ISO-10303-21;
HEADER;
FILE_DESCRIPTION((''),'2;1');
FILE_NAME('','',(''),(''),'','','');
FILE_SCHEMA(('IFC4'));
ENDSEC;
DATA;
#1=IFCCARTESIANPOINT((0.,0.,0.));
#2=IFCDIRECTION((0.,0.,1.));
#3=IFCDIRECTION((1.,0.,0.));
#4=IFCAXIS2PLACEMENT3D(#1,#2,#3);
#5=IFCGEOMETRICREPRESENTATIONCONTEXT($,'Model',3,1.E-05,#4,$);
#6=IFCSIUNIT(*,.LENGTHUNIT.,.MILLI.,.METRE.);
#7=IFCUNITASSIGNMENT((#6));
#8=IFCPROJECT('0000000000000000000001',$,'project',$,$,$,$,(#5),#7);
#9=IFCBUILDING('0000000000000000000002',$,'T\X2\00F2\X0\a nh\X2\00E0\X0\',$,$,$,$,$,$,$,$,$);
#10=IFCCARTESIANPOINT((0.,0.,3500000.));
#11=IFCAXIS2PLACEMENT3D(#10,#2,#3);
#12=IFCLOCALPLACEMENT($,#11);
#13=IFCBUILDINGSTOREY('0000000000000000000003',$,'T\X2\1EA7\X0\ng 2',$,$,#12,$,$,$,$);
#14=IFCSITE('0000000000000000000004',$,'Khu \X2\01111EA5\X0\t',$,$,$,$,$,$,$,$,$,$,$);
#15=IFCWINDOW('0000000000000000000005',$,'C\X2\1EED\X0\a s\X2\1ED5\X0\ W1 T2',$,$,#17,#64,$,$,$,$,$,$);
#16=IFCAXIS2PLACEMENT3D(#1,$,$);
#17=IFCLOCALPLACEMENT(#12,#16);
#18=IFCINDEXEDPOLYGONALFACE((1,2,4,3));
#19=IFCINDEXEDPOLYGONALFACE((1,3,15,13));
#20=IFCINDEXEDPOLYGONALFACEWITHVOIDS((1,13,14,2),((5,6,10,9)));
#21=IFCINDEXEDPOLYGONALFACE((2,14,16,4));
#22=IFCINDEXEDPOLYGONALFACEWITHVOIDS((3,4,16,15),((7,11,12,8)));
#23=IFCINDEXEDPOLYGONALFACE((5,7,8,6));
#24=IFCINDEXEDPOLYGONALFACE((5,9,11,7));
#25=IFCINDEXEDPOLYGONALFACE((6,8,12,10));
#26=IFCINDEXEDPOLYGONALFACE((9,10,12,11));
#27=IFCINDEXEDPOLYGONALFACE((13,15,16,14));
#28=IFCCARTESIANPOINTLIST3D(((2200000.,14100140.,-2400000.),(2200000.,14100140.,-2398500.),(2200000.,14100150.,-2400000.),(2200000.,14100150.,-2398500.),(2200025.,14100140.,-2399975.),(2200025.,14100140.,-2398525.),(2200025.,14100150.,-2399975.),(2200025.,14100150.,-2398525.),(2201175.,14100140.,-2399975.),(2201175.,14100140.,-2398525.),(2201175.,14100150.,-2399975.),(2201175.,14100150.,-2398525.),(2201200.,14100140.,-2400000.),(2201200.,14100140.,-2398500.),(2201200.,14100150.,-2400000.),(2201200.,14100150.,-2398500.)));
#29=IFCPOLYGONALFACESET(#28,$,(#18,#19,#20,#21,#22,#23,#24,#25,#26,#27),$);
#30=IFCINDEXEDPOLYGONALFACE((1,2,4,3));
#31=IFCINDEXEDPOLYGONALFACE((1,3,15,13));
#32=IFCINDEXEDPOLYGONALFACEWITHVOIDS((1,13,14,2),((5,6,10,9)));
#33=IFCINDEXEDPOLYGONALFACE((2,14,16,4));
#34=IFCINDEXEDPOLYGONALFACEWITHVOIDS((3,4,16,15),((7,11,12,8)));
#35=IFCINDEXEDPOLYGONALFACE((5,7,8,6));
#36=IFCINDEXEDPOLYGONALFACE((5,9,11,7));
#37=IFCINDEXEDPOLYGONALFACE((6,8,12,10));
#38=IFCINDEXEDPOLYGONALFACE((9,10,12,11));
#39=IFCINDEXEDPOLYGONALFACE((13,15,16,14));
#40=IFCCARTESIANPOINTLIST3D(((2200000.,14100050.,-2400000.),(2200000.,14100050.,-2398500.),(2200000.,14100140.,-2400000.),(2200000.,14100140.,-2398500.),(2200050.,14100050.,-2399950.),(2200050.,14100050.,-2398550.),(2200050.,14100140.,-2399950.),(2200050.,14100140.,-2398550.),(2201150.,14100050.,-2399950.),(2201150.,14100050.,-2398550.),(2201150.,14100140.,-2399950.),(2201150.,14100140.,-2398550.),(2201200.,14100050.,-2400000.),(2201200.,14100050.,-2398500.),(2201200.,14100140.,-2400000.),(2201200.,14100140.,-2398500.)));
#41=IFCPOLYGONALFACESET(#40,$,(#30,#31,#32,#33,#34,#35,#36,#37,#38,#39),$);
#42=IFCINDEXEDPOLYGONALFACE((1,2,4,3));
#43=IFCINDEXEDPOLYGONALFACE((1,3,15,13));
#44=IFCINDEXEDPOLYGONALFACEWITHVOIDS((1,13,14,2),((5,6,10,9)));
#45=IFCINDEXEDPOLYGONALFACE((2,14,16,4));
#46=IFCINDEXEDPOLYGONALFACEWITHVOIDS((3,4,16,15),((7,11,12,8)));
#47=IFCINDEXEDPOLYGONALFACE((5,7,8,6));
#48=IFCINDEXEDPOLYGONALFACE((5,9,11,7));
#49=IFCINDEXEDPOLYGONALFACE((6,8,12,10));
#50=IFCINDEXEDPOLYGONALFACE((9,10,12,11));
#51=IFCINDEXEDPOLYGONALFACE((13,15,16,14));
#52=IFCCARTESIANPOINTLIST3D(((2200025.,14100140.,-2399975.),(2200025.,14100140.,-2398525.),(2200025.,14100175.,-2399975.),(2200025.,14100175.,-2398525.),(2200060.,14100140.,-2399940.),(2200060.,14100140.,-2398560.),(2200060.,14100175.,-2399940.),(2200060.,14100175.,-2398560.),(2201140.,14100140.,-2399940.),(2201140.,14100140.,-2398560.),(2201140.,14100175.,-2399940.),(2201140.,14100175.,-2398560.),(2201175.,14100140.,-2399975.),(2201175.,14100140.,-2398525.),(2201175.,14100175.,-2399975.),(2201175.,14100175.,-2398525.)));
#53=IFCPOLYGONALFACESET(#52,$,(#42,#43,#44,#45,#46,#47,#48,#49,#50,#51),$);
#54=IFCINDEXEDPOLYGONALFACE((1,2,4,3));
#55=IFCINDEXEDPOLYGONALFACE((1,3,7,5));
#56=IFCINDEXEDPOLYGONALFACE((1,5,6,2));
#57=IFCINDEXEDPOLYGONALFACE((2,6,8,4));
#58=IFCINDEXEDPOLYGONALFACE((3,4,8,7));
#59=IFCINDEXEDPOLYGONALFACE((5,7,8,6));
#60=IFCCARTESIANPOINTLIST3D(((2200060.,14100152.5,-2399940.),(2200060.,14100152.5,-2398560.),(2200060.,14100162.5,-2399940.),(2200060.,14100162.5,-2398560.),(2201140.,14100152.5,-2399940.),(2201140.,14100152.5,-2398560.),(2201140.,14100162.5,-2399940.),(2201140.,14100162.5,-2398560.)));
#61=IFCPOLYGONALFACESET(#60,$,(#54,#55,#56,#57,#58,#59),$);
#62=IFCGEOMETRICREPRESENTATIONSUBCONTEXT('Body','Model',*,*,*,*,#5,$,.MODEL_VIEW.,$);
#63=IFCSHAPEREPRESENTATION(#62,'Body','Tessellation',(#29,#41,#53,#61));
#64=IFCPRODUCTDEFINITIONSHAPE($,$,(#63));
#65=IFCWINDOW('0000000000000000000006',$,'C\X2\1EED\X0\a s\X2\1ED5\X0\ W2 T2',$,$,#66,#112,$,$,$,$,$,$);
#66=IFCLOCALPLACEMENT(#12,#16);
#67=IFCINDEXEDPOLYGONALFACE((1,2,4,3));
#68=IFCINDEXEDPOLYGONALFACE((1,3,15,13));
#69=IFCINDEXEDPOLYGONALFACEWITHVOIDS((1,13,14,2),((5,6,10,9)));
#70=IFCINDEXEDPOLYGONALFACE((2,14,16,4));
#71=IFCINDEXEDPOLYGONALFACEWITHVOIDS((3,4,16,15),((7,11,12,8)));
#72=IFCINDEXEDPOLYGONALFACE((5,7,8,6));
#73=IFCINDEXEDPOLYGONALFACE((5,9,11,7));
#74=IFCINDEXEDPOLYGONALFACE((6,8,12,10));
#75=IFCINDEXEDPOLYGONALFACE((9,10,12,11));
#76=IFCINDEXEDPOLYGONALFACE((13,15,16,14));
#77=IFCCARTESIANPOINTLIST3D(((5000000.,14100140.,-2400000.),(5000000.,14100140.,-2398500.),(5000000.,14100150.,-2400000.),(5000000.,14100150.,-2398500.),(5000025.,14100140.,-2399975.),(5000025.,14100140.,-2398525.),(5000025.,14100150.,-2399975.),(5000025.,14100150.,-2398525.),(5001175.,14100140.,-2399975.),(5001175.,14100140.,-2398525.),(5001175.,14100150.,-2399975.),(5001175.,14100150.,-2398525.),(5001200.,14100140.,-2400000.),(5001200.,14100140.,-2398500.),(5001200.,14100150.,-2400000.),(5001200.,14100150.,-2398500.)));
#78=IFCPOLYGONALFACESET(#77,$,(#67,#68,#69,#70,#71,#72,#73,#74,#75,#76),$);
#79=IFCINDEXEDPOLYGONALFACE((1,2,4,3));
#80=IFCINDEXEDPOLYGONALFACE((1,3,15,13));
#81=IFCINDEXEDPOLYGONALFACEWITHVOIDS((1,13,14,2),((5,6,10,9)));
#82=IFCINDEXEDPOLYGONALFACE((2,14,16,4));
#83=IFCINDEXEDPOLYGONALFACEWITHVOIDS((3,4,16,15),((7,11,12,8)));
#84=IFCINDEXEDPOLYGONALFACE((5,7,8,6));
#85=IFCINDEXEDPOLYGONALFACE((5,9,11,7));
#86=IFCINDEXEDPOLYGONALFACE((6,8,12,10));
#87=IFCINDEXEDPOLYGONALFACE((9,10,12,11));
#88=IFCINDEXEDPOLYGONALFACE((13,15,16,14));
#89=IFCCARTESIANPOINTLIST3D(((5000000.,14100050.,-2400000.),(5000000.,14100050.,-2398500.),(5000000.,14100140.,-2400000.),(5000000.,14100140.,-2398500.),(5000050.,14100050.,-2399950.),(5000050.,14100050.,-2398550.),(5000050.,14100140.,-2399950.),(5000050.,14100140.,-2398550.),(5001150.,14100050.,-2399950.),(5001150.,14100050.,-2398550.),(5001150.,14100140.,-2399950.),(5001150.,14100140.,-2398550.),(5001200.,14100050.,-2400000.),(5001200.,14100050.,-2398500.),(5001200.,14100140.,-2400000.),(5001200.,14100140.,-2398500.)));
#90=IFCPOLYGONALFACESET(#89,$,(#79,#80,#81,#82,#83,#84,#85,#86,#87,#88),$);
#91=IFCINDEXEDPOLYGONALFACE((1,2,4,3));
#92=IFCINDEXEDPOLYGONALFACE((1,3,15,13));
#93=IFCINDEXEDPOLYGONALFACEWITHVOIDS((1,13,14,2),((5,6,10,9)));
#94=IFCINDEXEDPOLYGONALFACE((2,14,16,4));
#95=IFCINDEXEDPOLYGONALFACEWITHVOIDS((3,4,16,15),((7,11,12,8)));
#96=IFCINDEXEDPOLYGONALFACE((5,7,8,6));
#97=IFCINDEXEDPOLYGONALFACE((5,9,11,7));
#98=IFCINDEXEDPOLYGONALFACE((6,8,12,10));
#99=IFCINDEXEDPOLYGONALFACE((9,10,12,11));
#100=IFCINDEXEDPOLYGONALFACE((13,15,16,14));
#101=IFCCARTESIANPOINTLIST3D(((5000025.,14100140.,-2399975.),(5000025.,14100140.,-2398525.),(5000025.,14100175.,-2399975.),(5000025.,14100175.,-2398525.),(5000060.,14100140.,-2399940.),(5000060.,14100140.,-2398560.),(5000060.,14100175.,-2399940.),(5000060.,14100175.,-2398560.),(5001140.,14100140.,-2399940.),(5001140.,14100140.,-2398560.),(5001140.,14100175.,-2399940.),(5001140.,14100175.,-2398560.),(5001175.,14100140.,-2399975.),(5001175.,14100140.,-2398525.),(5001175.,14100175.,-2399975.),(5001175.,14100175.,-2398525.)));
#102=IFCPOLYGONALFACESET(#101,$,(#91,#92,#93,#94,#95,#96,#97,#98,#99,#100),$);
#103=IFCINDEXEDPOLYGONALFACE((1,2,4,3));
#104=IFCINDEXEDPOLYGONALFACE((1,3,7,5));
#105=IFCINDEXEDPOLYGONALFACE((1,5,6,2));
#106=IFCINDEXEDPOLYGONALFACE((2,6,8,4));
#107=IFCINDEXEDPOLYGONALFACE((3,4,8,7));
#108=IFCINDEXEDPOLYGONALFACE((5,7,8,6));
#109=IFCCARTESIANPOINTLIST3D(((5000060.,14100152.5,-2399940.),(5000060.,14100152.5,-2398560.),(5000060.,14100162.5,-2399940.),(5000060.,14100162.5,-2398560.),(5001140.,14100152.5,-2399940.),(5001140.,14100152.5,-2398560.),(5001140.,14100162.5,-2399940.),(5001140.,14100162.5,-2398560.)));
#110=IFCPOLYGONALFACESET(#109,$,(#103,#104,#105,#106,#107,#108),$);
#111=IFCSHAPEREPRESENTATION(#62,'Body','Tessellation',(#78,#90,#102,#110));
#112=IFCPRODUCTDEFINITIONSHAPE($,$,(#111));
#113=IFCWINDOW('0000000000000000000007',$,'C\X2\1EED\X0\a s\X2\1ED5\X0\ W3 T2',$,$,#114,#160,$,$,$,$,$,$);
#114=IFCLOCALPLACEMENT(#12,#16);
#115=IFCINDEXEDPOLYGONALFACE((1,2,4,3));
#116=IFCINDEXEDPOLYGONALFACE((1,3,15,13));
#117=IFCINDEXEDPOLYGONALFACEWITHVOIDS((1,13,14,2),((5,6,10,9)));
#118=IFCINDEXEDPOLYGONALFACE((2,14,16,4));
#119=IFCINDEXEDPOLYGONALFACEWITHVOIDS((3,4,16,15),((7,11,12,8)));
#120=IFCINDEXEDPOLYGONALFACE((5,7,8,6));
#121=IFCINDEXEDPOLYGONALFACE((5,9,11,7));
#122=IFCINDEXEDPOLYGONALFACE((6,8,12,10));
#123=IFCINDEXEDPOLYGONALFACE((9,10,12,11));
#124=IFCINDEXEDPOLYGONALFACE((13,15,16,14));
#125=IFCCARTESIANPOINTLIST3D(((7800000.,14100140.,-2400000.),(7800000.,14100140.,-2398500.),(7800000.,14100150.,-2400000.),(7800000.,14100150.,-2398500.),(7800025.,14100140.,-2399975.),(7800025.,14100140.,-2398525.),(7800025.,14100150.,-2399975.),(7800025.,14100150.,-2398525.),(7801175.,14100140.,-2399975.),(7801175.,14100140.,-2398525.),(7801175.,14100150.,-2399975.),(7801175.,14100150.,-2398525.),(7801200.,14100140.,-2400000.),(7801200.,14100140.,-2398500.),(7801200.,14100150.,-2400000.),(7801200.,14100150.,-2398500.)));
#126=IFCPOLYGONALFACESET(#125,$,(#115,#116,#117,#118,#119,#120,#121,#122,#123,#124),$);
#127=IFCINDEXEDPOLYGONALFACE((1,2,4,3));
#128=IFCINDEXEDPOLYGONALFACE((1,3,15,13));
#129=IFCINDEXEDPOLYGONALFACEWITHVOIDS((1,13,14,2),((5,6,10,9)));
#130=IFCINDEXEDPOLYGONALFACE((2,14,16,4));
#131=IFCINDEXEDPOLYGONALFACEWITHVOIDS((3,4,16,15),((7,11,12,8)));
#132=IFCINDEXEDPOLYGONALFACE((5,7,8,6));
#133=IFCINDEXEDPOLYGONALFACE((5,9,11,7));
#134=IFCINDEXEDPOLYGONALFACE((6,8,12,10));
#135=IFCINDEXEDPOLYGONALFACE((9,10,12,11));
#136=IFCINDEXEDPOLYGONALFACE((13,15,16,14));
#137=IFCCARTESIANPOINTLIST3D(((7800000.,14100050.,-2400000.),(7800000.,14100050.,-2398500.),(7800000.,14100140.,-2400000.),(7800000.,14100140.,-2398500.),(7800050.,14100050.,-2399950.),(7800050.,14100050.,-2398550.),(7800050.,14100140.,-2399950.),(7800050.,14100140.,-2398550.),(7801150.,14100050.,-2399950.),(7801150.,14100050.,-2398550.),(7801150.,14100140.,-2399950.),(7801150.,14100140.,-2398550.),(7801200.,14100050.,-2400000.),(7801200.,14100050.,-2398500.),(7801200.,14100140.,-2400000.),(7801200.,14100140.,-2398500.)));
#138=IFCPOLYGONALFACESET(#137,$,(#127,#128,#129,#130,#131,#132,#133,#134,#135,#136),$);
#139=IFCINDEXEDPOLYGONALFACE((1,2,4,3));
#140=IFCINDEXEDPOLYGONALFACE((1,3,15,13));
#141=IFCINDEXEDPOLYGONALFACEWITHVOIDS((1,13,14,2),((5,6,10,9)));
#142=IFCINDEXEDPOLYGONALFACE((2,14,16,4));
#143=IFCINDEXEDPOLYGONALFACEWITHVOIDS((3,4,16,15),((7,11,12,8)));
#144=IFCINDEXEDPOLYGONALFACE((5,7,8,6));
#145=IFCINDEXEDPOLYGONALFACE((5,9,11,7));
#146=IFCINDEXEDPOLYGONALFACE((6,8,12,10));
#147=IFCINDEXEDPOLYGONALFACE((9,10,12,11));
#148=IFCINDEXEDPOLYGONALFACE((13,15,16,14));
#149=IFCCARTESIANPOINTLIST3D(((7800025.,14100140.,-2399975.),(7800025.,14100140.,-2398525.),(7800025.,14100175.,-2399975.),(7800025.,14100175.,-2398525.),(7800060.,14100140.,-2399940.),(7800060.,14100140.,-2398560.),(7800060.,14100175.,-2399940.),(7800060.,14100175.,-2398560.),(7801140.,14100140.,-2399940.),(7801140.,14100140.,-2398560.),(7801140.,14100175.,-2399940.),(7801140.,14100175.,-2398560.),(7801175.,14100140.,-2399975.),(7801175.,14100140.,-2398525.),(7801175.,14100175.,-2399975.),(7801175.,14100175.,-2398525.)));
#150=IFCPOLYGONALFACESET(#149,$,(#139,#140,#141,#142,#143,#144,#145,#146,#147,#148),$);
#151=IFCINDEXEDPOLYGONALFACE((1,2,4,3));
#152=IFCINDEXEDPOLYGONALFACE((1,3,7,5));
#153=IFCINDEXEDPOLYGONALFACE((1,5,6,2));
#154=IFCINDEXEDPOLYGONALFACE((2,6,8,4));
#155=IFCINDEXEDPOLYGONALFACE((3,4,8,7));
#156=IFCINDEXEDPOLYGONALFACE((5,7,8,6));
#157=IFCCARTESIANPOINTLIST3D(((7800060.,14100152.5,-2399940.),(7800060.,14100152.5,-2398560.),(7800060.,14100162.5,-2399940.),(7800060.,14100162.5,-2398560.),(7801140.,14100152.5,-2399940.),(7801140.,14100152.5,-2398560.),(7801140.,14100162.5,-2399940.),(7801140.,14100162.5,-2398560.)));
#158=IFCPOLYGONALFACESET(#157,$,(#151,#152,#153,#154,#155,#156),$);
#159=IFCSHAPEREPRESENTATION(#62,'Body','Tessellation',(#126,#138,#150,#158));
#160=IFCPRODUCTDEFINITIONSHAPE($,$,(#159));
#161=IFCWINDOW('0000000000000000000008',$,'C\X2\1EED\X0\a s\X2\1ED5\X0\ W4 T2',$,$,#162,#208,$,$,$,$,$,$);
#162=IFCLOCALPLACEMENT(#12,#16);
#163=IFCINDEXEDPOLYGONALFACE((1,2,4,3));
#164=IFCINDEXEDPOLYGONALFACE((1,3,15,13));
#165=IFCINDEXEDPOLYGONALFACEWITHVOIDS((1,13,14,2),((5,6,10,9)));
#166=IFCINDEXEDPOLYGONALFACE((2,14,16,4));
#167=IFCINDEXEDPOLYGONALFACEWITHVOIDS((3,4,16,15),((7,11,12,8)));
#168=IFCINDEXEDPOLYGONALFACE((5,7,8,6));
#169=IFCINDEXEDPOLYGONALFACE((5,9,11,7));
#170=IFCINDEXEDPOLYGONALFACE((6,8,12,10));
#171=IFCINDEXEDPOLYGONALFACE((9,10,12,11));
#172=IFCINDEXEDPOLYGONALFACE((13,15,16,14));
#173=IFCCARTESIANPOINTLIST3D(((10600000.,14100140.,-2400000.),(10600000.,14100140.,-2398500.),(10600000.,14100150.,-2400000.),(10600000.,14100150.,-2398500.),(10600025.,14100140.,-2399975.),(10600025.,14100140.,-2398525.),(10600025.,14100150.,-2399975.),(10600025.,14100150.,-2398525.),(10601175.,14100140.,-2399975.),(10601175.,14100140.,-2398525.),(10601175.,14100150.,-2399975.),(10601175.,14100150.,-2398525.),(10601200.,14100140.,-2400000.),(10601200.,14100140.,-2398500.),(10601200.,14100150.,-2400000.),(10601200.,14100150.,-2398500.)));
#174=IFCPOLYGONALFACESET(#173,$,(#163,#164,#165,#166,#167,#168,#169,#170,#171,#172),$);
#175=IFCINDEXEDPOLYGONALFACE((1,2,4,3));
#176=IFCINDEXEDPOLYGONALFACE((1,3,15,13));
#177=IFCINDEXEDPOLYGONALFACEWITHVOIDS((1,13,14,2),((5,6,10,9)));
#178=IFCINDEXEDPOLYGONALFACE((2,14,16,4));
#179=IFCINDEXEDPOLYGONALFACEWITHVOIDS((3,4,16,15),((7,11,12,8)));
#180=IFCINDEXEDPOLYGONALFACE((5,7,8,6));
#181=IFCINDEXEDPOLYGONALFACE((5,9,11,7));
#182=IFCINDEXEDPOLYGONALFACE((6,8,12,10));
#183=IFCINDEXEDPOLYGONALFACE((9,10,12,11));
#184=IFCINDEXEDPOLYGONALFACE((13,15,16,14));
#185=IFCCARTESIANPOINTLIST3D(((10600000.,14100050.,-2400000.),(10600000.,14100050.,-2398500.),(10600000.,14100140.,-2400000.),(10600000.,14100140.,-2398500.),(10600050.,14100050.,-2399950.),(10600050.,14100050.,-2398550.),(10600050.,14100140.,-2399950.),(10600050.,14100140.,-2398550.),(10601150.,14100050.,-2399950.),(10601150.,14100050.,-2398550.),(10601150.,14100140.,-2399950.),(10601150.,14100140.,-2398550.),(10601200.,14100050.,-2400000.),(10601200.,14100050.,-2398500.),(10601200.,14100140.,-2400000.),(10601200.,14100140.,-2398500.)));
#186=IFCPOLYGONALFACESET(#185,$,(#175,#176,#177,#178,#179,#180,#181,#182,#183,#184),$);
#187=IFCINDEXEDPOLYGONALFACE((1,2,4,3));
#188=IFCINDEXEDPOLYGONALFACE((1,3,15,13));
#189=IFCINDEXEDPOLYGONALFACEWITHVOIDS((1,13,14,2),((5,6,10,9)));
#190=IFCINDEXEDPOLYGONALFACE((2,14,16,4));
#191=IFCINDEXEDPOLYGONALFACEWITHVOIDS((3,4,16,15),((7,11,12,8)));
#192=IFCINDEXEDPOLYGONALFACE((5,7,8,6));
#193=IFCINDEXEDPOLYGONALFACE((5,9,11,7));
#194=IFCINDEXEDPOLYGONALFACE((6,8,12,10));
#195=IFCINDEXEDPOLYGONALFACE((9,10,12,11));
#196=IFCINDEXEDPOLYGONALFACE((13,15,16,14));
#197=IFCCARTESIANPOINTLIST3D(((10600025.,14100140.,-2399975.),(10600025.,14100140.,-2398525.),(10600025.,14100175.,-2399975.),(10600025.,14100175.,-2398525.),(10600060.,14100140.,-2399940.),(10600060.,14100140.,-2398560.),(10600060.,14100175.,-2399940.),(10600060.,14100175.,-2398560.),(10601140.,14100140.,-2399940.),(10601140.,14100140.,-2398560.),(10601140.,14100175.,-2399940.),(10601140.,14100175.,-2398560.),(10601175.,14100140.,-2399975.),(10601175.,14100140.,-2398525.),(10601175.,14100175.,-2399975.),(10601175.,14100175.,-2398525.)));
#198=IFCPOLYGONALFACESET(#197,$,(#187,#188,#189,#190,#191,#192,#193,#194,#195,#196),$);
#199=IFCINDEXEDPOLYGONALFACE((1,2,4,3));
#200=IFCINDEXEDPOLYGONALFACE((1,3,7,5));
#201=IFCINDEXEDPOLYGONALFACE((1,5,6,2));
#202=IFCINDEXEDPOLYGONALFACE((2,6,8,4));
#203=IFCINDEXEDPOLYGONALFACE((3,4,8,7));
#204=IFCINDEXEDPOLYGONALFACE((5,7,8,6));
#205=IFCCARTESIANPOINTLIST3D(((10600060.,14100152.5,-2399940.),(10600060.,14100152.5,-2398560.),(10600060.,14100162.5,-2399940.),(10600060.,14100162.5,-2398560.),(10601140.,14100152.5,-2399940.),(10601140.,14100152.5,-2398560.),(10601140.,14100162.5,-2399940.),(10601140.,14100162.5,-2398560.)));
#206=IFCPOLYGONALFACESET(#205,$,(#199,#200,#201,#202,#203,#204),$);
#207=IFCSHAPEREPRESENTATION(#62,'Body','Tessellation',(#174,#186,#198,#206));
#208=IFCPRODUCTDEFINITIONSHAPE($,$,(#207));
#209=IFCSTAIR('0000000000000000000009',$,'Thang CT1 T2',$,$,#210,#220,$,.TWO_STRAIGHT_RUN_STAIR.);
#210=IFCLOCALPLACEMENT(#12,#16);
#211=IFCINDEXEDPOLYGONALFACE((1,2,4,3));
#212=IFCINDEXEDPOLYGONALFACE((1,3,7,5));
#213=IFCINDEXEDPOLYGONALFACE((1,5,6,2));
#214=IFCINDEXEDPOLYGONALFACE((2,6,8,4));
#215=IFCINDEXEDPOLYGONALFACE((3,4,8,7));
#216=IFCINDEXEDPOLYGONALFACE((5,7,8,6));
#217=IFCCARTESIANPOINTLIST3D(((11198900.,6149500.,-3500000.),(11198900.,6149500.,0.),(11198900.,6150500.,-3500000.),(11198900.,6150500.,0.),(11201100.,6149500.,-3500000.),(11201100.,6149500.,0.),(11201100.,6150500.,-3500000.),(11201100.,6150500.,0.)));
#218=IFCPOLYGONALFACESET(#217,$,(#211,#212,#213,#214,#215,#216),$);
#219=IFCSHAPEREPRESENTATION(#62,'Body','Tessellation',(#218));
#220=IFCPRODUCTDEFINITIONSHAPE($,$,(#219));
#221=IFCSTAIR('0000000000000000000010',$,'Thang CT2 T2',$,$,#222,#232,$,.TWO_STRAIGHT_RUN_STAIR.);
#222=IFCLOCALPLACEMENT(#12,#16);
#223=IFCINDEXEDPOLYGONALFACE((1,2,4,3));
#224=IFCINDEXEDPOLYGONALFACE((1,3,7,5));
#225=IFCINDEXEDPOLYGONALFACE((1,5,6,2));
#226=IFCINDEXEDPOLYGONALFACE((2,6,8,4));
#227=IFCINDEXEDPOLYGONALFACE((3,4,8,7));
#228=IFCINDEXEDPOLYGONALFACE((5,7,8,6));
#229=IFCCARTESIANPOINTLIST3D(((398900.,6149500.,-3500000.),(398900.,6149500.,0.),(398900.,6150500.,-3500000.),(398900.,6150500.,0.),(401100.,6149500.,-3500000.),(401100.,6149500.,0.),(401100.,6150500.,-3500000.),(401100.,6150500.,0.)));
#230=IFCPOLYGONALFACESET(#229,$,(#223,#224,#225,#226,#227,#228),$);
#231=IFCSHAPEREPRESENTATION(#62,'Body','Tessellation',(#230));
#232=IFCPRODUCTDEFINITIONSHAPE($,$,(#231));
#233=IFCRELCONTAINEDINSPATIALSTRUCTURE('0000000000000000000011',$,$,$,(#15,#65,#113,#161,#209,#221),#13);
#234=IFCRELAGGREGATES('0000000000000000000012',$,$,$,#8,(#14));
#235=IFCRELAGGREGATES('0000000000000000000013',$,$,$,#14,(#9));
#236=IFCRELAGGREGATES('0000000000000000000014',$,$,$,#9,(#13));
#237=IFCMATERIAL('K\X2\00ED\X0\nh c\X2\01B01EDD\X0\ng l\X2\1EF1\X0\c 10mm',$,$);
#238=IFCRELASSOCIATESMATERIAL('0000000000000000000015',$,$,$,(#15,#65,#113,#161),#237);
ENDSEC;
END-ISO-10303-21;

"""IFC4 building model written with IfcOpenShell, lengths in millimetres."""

from ifc_helpers import new_model, entity, si_unit, frame, origin_with_axes, place, context, subcontext, project, spatial, line, indexed_curve, outline, extrude, material, element, save


model = new_model("IFC4")

# Units and contexts
model_context = context("Model", 3, precision=1e-05, world=origin_with_axes())
body_context = subcontext(model_context, "Body", "Model", "MODEL_VIEW")
ifc_project = project(units=[si_unit("LENGTHUNIT", "METRE", prefix="MILLI")], contexts=[model_context])

# Site, building, storey
site = spatial("IfcSite", under=ifc_project, Name="Khu đất")
building = spatial("IfcBuilding", under=site, Name="Tòa nhà")
storey_placement = place(None, frame((0.0, 0.0, 3500000.0), z_axis=(0.0, 0.0, 1.0), x_axis=(1.0, 0.0, 0.0)))
storey = spatial("IfcBuildingStorey", under=building, at=storey_placement, Name="Tầng 2")

# Windows
ifc_material_1 = material(Name="Kính cường lực 10mm")
for number, where, z_axis, x_axis, name in (
    (1, (2200000.0, 14100000.0, -2400000.0), (0.0, 0.0, 1.0), (1.0, 0.0, 0.0), "Cửa sổ W1 T2"),
    (2, (5000000.0, 14100000.0, -2400000.0), (0.0, 0.0, 1.0), (1.0, 0.0, 0.0), "Cửa sổ W2 T2"),
    (3, (7800000.0, 14100000.0, -2400000.0), (0.0, 0.0, 1.0), (1.0, 0.0, 0.0), "Cửa sổ W3 T2"),
    (4, (10600000.0, 14100000.0, -2400000.0), (0.0, 0.0, 1.0), (1.0, 0.0, 0.0), "Cửa sổ W4 T2"),
):
    element("IfcWindow", number, at=place(storey_placement, frame(where, z_axis=z_axis, x_axis=x_axis)), inside=storey, material=ifc_material_1, Name=name, context=body_context, shape_type="SolidModel", body=[
        extrude(outline(indexed_curve([(0.0, 0.0), (1200.0, 0.0), (1200.0, 1500.0), (0.0, 1500.0)], segments=[line(1, 2, 3, 4, 1)]), holes=[indexed_curve([(25.0, 25.0), (1175.0, 25.0), (1175.0, 1475.0), (25.0, 1475.0)], segments=[line(1, 2, 3, 4, 1)])]), frame((0.0, 140.0, 0.0), z_axis=(0.0, -1.0, 0.0), x_axis=(1.0, 0.0, 0.0)), (0.0, 0.0, -1.0), 10.0),
        extrude(outline(indexed_curve([(0.0, 0.0), (1200.0, 0.0), (1200.0, 1500.0), (0.0, 1500.0)], segments=[line(1, 2, 3, 4, 1)]), holes=[indexed_curve([(50.0, 50.0), (1150.0, 50.0), (1150.0, 1450.0), (50.0, 1450.0)], segments=[line(1, 2, 3, 4, 1)])]), frame((0.0, 50.0, 0.0), z_axis=(0.0, -1.0, 0.0), x_axis=(1.0, 0.0, 0.0)), (0.0, 0.0, -1.0), 90.0),
        extrude(outline(indexed_curve([(0.0, 0.0), (1150.0, 0.0), (1150.0, 1450.0), (0.0, 1450.0)], segments=[line(1, 2, 3, 4, 1)]), holes=[indexed_curve([(35.0, 35.0), (1115.0, 35.0), (1115.0, 1415.0), (35.0, 1415.0)], segments=[line(1, 2, 3, 4, 1)])]), frame((25.0, 140.0, 25.0), z_axis=(0.0, -1.0, 0.0), x_axis=(1.0, 0.0, 0.0)), (0.0, 0.0, -1.0), 35.0),
        extrude(outline(indexed_curve([(35.0, 35.0), (1115.0, 35.0), (1115.0, 1415.0), (35.0, 1415.0)], segments=[line(1, 2, 3, 4, 1)])), frame((25.0, 152.5, 25.0), z_axis=(0.0, -1.0, 0.0), x_axis=(1.0, 0.0, 0.0)), (0.0, 0.0, -1.0), 10.0),
    ])

# Stairs
for number, where, z_axis, x_axis, name in (
    (5, (11200000.0, 6150000.0, -3500000.0), (0.0, 0.0, 1.0), (1.0, 0.0, 0.0), "Thang CT1 T2"),
    (6, (400000.0, 6150000.0, -3500000.0), (0.0, 0.0, 1.0), (1.0, 0.0, 0.0), "Thang CT2 T2"),
):
    element("IfcStair", number, at=place(storey_placement, frame(where, z_axis=z_axis, x_axis=x_axis)), inside=storey, Name=name, PredefinedType="TWO_STRAIGHT_RUN_STAIR", context=body_context, shape_type="SweptSolid", body=[
        extrude(entity("IfcRectangleProfileDef", None, None, None, 2200.0, 1000.0), origin_with_axes(), (0.0, 0.0, 1.0), 3500000.0),
    ])

save(model, "model.ifc")
